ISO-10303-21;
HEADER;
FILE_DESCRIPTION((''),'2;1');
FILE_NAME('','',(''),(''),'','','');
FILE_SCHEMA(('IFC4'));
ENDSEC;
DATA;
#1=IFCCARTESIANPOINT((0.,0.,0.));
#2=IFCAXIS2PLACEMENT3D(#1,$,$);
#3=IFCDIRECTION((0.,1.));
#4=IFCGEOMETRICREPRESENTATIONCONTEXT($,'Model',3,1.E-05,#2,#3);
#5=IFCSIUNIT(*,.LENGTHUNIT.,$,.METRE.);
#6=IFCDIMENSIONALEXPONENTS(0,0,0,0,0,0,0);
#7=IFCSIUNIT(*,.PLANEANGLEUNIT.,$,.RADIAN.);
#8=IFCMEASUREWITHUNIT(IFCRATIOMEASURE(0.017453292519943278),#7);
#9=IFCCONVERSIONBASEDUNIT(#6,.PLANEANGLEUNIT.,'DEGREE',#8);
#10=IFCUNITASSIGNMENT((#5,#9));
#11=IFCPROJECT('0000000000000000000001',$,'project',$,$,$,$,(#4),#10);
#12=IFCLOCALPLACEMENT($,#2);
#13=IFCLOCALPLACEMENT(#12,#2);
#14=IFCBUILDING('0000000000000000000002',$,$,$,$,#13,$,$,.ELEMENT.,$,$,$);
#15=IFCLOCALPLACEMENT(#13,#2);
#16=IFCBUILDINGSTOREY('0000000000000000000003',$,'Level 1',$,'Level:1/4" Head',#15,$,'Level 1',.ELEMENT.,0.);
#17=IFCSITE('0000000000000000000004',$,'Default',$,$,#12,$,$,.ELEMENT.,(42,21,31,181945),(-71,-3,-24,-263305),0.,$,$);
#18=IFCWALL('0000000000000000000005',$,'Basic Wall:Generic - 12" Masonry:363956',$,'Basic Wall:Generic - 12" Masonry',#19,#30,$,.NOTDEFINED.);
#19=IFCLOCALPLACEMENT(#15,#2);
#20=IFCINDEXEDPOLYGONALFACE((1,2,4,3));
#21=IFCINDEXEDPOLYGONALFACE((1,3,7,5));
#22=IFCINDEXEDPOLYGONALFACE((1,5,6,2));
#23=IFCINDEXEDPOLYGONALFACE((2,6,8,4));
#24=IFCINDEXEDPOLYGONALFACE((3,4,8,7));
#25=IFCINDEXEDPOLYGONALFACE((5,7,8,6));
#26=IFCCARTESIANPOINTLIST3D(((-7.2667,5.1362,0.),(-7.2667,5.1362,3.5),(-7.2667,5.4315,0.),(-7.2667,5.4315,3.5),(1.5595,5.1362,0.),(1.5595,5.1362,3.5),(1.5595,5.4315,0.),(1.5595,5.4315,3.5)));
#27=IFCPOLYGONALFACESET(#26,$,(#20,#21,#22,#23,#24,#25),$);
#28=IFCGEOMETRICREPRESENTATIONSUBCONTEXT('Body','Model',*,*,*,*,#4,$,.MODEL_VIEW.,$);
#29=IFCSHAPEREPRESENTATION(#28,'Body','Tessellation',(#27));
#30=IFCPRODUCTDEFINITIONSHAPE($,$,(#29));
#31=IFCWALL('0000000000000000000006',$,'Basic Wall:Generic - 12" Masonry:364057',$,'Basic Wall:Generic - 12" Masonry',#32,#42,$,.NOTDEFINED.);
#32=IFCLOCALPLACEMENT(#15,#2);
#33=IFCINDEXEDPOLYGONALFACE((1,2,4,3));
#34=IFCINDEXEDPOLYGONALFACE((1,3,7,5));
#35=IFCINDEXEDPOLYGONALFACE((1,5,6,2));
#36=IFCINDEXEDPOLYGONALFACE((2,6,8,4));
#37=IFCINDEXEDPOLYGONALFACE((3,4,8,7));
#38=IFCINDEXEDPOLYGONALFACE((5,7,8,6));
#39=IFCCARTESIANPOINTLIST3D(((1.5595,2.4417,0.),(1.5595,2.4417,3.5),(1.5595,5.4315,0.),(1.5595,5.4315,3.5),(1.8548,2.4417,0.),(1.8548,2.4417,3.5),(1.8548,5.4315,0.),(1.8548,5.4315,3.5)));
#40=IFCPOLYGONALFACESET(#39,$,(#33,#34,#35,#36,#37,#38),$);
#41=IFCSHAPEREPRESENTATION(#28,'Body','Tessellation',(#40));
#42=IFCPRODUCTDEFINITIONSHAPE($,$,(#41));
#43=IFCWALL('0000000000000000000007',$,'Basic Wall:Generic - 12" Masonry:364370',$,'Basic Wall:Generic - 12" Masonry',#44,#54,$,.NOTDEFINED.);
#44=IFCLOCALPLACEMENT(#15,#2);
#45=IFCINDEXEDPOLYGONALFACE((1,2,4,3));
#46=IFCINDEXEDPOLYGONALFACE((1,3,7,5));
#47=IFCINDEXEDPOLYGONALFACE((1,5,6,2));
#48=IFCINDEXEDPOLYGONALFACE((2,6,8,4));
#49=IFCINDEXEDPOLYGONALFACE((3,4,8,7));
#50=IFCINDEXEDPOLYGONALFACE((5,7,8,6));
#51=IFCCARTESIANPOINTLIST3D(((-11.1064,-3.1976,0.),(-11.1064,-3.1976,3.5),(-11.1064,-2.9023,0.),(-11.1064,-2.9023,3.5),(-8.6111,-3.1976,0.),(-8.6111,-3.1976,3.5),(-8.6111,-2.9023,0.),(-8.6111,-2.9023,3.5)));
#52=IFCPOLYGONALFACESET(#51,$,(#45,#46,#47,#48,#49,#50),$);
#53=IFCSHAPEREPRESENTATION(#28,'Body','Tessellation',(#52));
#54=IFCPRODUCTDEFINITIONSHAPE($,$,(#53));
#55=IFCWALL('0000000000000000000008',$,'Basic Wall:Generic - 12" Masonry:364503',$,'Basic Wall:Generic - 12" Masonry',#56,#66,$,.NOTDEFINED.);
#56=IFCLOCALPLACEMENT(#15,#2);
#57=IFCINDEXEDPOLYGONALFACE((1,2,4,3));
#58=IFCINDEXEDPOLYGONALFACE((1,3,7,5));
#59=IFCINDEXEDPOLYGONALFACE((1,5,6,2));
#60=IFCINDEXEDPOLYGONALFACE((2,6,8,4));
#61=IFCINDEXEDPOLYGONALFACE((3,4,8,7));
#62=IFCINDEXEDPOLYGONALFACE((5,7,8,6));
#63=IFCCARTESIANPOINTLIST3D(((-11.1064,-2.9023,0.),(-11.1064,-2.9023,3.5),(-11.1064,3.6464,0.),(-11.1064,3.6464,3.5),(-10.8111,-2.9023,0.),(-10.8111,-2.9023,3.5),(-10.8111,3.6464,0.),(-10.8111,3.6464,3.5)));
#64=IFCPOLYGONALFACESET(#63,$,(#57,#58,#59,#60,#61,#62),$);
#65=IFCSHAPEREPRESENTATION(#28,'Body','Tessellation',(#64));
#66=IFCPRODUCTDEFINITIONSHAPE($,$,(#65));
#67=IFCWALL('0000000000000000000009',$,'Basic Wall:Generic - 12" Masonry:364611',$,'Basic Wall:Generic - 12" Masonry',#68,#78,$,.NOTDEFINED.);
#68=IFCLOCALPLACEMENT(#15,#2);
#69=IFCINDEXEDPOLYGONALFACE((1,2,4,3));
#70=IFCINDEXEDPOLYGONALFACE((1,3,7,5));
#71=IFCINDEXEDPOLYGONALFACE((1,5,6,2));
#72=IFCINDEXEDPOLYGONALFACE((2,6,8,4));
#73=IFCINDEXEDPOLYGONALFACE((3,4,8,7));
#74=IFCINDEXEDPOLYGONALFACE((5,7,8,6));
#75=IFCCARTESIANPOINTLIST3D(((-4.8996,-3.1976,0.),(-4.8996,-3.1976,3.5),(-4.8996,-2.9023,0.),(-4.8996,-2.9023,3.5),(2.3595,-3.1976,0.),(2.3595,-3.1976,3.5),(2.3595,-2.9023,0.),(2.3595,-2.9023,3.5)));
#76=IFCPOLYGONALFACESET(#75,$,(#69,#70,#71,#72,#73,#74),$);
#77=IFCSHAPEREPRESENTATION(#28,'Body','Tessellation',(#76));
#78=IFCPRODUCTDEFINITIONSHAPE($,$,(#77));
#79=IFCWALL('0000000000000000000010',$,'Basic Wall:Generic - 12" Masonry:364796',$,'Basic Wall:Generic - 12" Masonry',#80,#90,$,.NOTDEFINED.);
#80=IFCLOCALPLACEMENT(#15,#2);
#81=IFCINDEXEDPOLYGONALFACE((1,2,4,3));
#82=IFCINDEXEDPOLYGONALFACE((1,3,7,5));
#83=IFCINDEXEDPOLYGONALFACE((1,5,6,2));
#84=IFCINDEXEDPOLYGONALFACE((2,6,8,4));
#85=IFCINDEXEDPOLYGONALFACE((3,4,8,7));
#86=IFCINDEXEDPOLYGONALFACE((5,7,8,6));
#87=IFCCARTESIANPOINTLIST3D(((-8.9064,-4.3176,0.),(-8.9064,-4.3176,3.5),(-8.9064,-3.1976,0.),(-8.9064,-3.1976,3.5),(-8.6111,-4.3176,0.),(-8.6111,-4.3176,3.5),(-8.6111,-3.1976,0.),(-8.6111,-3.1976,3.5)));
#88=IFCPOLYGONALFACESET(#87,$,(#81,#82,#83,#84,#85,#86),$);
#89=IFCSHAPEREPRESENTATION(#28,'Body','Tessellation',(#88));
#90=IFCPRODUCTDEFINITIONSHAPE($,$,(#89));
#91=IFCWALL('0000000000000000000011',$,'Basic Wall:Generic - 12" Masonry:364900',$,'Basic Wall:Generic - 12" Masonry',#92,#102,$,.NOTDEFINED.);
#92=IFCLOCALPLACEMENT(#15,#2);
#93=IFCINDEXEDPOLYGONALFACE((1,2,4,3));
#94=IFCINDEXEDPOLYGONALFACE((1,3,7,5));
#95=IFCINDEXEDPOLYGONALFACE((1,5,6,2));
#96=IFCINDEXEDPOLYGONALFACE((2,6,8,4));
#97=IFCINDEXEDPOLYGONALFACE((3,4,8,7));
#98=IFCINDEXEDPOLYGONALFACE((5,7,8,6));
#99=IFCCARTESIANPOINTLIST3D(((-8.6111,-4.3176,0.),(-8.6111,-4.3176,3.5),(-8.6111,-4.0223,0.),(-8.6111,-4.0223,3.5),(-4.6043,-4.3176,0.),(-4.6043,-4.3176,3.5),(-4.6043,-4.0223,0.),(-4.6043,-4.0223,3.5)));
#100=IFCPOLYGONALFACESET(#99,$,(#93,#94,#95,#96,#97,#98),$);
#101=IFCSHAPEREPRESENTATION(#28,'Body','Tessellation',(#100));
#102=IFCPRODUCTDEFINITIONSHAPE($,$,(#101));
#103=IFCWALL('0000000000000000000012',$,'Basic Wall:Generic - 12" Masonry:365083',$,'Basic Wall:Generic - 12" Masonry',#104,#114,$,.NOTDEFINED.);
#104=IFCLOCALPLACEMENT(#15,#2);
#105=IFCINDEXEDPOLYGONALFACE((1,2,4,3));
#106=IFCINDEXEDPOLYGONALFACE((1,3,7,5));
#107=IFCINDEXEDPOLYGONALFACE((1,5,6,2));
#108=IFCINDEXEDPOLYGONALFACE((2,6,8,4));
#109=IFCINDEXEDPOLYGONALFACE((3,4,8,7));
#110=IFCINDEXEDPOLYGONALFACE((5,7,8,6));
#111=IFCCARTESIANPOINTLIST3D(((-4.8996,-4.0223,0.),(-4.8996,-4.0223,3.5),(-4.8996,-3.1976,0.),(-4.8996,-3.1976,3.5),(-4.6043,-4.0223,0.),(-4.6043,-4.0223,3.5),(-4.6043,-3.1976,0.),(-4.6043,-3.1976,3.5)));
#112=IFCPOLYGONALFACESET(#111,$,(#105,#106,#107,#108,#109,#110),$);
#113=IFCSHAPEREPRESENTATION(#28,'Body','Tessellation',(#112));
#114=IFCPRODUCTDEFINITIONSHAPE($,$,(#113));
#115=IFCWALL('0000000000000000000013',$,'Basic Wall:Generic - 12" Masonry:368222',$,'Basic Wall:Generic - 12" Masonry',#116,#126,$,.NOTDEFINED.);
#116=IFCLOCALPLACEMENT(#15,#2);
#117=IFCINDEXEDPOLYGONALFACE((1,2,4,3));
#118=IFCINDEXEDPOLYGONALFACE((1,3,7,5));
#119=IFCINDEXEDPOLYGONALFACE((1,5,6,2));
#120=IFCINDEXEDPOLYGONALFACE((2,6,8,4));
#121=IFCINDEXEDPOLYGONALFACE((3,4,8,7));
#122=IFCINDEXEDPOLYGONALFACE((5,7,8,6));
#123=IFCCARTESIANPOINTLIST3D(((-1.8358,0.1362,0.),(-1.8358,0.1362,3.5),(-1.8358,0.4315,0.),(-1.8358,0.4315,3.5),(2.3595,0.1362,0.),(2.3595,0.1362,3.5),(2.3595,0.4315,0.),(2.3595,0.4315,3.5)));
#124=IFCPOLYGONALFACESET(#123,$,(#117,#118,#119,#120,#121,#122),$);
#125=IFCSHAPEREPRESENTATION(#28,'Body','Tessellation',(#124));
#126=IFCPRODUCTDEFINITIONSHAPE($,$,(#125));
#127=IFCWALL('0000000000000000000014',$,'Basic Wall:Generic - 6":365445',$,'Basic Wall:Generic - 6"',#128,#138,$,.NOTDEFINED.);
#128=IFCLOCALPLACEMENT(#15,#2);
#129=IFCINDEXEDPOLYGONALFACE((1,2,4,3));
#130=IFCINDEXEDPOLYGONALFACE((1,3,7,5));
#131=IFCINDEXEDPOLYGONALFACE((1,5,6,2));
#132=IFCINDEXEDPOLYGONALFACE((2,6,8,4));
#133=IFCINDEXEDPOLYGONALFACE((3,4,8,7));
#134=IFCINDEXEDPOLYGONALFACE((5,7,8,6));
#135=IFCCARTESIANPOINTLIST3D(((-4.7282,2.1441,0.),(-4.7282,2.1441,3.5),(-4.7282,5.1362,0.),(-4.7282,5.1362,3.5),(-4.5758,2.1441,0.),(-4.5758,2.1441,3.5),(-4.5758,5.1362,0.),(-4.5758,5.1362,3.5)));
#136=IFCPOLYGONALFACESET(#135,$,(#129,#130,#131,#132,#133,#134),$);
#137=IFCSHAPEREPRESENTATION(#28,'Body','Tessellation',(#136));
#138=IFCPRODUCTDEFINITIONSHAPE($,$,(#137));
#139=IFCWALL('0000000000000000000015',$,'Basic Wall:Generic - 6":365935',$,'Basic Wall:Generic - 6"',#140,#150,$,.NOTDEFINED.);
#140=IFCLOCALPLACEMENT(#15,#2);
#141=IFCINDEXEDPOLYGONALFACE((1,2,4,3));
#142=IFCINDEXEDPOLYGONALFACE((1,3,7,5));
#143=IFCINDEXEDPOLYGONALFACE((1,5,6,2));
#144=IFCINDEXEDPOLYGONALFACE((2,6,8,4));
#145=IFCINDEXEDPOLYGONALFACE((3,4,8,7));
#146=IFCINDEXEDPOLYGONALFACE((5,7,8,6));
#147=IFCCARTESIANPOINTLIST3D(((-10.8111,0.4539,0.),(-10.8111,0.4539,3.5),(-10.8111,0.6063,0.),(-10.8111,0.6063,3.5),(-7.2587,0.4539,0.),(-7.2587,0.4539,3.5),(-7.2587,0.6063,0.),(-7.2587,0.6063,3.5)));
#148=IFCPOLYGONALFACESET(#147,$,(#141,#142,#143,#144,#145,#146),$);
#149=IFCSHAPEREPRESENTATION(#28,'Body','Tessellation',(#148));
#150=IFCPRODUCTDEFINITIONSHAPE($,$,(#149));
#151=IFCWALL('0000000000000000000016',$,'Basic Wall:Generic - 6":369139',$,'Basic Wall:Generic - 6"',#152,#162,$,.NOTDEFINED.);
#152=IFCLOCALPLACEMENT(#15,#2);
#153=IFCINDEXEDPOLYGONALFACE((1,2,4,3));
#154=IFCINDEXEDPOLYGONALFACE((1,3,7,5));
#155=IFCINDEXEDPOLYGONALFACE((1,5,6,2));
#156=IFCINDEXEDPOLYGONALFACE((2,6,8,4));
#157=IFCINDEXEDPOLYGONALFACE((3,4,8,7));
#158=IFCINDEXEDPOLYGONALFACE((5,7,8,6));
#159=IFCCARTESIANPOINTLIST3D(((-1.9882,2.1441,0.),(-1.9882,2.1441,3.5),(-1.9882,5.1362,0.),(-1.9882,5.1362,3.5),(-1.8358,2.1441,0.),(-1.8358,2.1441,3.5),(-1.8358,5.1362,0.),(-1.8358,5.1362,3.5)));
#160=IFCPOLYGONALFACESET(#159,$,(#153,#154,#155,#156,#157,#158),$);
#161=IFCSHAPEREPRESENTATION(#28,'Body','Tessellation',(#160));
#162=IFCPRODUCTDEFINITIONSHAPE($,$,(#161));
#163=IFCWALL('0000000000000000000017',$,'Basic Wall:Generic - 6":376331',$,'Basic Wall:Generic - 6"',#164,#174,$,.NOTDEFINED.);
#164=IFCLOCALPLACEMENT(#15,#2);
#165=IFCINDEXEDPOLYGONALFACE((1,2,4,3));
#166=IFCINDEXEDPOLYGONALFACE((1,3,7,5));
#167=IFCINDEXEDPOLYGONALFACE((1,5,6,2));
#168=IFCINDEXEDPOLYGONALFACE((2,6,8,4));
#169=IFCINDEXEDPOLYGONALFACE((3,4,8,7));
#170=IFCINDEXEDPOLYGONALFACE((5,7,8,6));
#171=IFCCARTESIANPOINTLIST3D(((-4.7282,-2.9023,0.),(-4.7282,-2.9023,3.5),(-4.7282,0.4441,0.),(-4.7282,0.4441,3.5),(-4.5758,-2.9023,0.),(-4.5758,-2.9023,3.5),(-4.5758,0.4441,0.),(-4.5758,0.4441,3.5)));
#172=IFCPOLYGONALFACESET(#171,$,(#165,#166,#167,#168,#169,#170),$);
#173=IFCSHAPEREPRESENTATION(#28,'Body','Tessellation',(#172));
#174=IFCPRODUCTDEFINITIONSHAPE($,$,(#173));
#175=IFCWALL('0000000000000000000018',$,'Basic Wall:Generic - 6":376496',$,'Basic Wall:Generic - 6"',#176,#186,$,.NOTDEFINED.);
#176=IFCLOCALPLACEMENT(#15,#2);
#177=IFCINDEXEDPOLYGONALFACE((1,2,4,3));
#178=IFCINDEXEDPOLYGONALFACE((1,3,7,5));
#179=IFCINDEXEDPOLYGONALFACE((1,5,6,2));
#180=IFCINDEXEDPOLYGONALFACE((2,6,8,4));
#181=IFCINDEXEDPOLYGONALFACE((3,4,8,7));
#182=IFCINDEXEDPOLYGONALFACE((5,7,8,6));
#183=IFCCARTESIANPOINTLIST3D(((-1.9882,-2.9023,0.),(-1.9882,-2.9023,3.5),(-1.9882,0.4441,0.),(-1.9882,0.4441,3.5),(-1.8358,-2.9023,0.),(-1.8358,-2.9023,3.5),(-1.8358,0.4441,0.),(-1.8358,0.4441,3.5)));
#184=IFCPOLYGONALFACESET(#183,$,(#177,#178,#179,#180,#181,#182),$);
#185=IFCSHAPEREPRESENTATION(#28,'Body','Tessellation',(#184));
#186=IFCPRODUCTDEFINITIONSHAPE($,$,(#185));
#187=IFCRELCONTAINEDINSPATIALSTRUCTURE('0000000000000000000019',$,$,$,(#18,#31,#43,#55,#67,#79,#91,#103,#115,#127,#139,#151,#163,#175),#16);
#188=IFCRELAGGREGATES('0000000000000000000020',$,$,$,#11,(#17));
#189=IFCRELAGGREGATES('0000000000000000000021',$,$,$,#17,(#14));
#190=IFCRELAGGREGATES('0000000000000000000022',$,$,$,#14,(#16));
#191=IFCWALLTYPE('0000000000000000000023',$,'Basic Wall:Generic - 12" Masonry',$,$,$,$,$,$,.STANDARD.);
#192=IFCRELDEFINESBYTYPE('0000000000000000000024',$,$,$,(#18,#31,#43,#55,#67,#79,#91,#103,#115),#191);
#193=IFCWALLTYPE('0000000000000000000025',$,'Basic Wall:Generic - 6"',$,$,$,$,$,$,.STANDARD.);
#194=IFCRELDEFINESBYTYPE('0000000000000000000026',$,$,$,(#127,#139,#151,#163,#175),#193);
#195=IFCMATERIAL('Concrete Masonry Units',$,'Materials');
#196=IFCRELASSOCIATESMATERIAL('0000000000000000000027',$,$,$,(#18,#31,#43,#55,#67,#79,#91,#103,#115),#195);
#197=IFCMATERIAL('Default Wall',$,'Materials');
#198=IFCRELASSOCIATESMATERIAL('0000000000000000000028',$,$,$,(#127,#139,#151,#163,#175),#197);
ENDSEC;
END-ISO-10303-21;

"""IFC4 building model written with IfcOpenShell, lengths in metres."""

from ifc_helpers import new_model, entity, si_unit, converted_unit, direction, frame, origin, place, context, subcontext, project, spatial, indexed_curve, outline, extrude, material, type_object, element, save


model = new_model("IFC4")

# Units and contexts
model_context = context("Model", 3, precision=1e-05, world=origin(), true_north=direction((0.0, 1.0)))
body_context = subcontext(model_context, "Body", "Model", "MODEL_VIEW")
ifc_project = project(units=[si_unit("LENGTHUNIT", "METRE"), converted_unit("PLANEANGLEUNIT", "DEGREE", entity("IfcRatioMeasure", 0.017453292519943278), si_unit("PLANEANGLEUNIT", "RADIAN"), dimensions=[0, 0, 0, 0, 0, 0, 0])], contexts=[model_context])

# Site, building, storey
site_placement = place(None, origin())
site = spatial("IfcSite", under=ifc_project, at=site_placement, Name="Default", CompositionType="ELEMENT", RefLatitude=(42, 21, 31, 181945), RefLongitude=(-71, -3, -24, -263305), RefElevation=0.0)
building_placement = place(site_placement, origin())
building = spatial("IfcBuilding", under=site, at=building_placement, CompositionType="ELEMENT")
storey_placement = place(building_placement, origin())
storey = spatial("IfcBuildingStorey", under=building, at=storey_placement, Name="Level 1", ObjectType="Level:1/4\" Head", LongName="Level 1", CompositionType="ELEMENT", Elevation=0.0)

# Walls
ifc_material_1 = material(Name="Concrete Masonry Units", Category="Materials")
wall_type_1 = type_object("IfcWallType", Name="Basic Wall:Generic - 12\" Masonry", PredefinedType="STANDARD")
wall_1_placement = place(storey_placement, frame((1.5595, 5.2838, 0.0), z_axis=(0.0, 0.0, 1.0), x_axis=(-1.0, 0.0, 0.0)))
element("IfcWall", 1, at=wall_1_placement, inside=storey, type_object=wall_type_1, material=ifc_material_1, Name="Basic Wall:Generic - 12\" Masonry:363956", ObjectType="Basic Wall:Generic - 12\" Masonry", PredefinedType="NOTDEFINED", context=body_context, shape_type="SweptSolid", body=[
    extrude(outline(indexed_curve([(8.8262, 0.1476), (0.0, 0.1476), (0.0, -0.1476), (8.8262, -0.1476), (8.8262, 0.1476)], self_intersect=False)), origin(), (0.0, 0.0, 1.0), 3.5),
])
wall_2_placement = place(storey_placement, frame((1.7071, 5.4315, 0.0), z_axis=(0.0, 0.0, 1.0), x_axis=(0.0, -1.0, 0.0)))
element("IfcWall", 2, at=wall_2_placement, inside=storey, type_object=wall_type_1, material=ifc_material_1, Name="Basic Wall:Generic - 12\" Masonry:364057", ObjectType="Basic Wall:Generic - 12\" Masonry", PredefinedType="NOTDEFINED", context=body_context, shape_type="SweptSolid", body=[
    extrude(outline(indexed_curve([(2.9897, 0.1476), (0.0, 0.1476), (0.0, -0.1476), (2.9897, -0.1476), (2.9897, 0.1476)], self_intersect=False)), origin(), (0.0, 0.0, 1.0), 3.5),
])
wall_3_placement = place(storey_placement, frame((-8.6111, -3.0499, 0.0), z_axis=(0.0, 0.0, 1.0), x_axis=(-1.0, 0.0, 0.0)))
element("IfcWall", 3, at=wall_3_placement, inside=storey, type_object=wall_type_1, material=ifc_material_1, Name="Basic Wall:Generic - 12\" Masonry:364370", ObjectType="Basic Wall:Generic - 12\" Masonry", PredefinedType="NOTDEFINED", context=body_context, shape_type="SweptSolid", body=[
    extrude(outline(indexed_curve([(2.4953, 0.1476), (0.0, 0.1476), (0.0, -0.1476), (2.4953, -0.1476), (2.4953, 0.1476)], self_intersect=False)), origin(), (0.0, 0.0, 1.0), 3.5),
])
wall_4_placement = place(storey_placement, frame((-10.9587, 3.6464, 0.0), z_axis=(0.0, 0.0, 1.0), x_axis=(0.0, -1.0, 0.0)))
element("IfcWall", 4, at=wall_4_placement, inside=storey, type_object=wall_type_1, material=ifc_material_1, Name="Basic Wall:Generic - 12\" Masonry:364503", ObjectType="Basic Wall:Generic - 12\" Masonry", PredefinedType="NOTDEFINED", context=body_context, shape_type="SweptSolid", body=[
    extrude(outline(indexed_curve([(6.5487, 0.1476), (0.0, 0.1476), (0.0, -0.1476), (6.5487, -0.1476), (6.5487, 0.1476)], self_intersect=False)), origin(), (0.0, 0.0, 1.0), 3.5),
])
wall_5_placement = place(storey_placement, frame((2.3595, -3.0499, 0.0), z_axis=(0.0, 0.0, 1.0), x_axis=(-1.0, 0.0, 0.0)))
element("IfcWall", 5, at=wall_5_placement, inside=storey, type_object=wall_type_1, material=ifc_material_1, Name="Basic Wall:Generic - 12\" Masonry:364611", ObjectType="Basic Wall:Generic - 12\" Masonry", PredefinedType="NOTDEFINED", context=body_context, shape_type="SweptSolid", body=[
    extrude(outline(indexed_curve([(7.2591, 0.1476), (0.0, 0.1476), (0.0, -0.1476), (7.2591, -0.1476), (7.2591, 0.1476)], self_intersect=False)), origin(), (0.0, 0.0, 1.0), 3.5),
])
wall_6_placement = place(storey_placement, frame((-8.7587, -3.1976, 0.0), z_axis=(0.0, 0.0, 1.0), x_axis=(0.0, -1.0, 0.0)))
element("IfcWall", 6, at=wall_6_placement, inside=storey, type_object=wall_type_1, material=ifc_material_1, Name="Basic Wall:Generic - 12\" Masonry:364796", ObjectType="Basic Wall:Generic - 12\" Masonry", PredefinedType="NOTDEFINED", context=body_context, shape_type="SweptSolid", body=[
    extrude(outline(indexed_curve([(1.12, 0.1476), (0.0, 0.1476), (0.0, -0.1476), (1.12, -0.1476), (1.12, 0.1476)], self_intersect=False)), origin(), (0.0, 0.0, 1.0), 3.5),
])
wall_7_placement = place(storey_placement, frame((-4.6043, -4.1699, 0.0), z_axis=(0.0, 0.0, 1.0), x_axis=(-1.0, 0.0, 0.0)))
element("IfcWall", 7, at=wall_7_placement, inside=storey, type_object=wall_type_1, material=ifc_material_1, Name="Basic Wall:Generic - 12\" Masonry:364900", ObjectType="Basic Wall:Generic - 12\" Masonry", PredefinedType="NOTDEFINED", context=body_context, shape_type="SweptSolid", body=[
    extrude(outline(indexed_curve([(4.0068, 0.1476), (0.0, 0.1476), (0.0, -0.1476), (4.0068, -0.1476), (4.0068, 0.1476)], self_intersect=False)), origin(), (0.0, 0.0, 1.0), 3.5),
])
wall_8_placement = place(storey_placement, frame((-4.752, -4.0223, 0.0), z_axis=(0.0, 0.0, 1.0), x_axis=(0.0, 1.0, 0.0)))
element("IfcWall", 8, at=wall_8_placement, inside=storey, type_object=wall_type_1, material=ifc_material_1, Name="Basic Wall:Generic - 12\" Masonry:365083", ObjectType="Basic Wall:Generic - 12\" Masonry", PredefinedType="NOTDEFINED", context=body_context, shape_type="SweptSolid", body=[
    extrude(outline(indexed_curve([(0.8247, 0.1476), (0.0, 0.1476), (0.0, -0.1476), (0.8247, -0.1476), (0.8247, 0.1476)], self_intersect=False)), origin(), (0.0, 0.0, 1.0), 3.5),
])
wall_9_placement = place(storey_placement, frame((-1.8358, 0.2838, 0.0)))
element("IfcWall", 9, at=wall_9_placement, inside=storey, type_object=wall_type_1, material=ifc_material_1, Name="Basic Wall:Generic - 12\" Masonry:368222", ObjectType="Basic Wall:Generic - 12\" Masonry", PredefinedType="NOTDEFINED", context=body_context, shape_type="SweptSolid", body=[
    extrude(outline(indexed_curve([(4.1953, 0.1476), (0.0, 0.1476), (0.0, -0.1476), (4.1953, -0.1476), (4.1953, 0.1476)], self_intersect=False)), origin(), (0.0, 0.0, 1.0), 3.5),
])
ifc_material_2 = material(Name="Default Wall", Category="Materials")
wall_type_2 = type_object("IfcWallType", Name="Basic Wall:Generic - 6\"", PredefinedType="STANDARD")
wall_10_placement = place(storey_placement, frame((-4.652, 5.1362, 0.0), z_axis=(0.0, 0.0, 1.0), x_axis=(0.0, -1.0, 0.0)))
element("IfcWall", 10, at=wall_10_placement, inside=storey, type_object=wall_type_2, material=ifc_material_2, Name="Basic Wall:Generic - 6\":365445", ObjectType="Basic Wall:Generic - 6\"", PredefinedType="NOTDEFINED", context=body_context, shape_type="SweptSolid", body=[
    extrude(outline(indexed_curve([(2.9921, 0.0762), (0.0, 0.0762), (0.0, -0.0762), (2.9921, -0.0762), (2.9921, 0.0762)], self_intersect=False)), origin(), (0.0, 0.0, 1.0), 3.5),
])
wall_11_placement = place(storey_placement, frame((-10.8111, 0.5301, 0.0)))
element("IfcWall", 11, at=wall_11_placement, inside=storey, type_object=wall_type_2, material=ifc_material_2, Name="Basic Wall:Generic - 6\":365935", ObjectType="Basic Wall:Generic - 6\"", PredefinedType="NOTDEFINED", context=body_context, shape_type="SweptSolid", body=[
    extrude(outline(indexed_curve([(3.5524, 0.0762), (0.0, 0.0762), (0.0, -0.0762), (3.5524, -0.0762), (3.5524, 0.0762)], self_intersect=False)), origin(), (0.0, 0.0, 1.0), 3.5),
])
wall_12_placement = place(storey_placement, frame((-1.912, 5.1362, 0.0), z_axis=(0.0, 0.0, 1.0), x_axis=(0.0, -1.0, 0.0)))
element("IfcWall", 12, at=wall_12_placement, inside=storey, type_object=wall_type_2, material=ifc_material_2, Name="Basic Wall:Generic - 6\":369139", ObjectType="Basic Wall:Generic - 6\"", PredefinedType="NOTDEFINED", context=body_context, shape_type="SweptSolid", body=[
    extrude(outline(indexed_curve([(2.9921, 0.0762), (0.0, 0.0762), (0.0, -0.0762), (2.9921, -0.0762), (2.9921, 0.0762)], self_intersect=False)), origin(), (0.0, 0.0, 1.0), 3.5),
])
wall_13_placement = place(storey_placement, frame((-4.652, 0.4441, 0.0), z_axis=(0.0, 0.0, 1.0), x_axis=(0.0, -1.0, 0.0)))
element("IfcWall", 13, at=wall_13_placement, inside=storey, type_object=wall_type_2, material=ifc_material_2, Name="Basic Wall:Generic - 6\":376331", ObjectType="Basic Wall:Generic - 6\"", PredefinedType="NOTDEFINED", context=body_context, shape_type="SweptSolid", body=[
    extrude(outline(indexed_curve([(3.3464, 0.0762), (0.0, 0.0762), (0.0, -0.0762), (3.3464, -0.0762), (3.3464, 0.0762)], self_intersect=False)), origin(), (0.0, 0.0, 1.0), 3.5),
])
wall_14_placement = place(storey_placement, frame((-1.912, 0.4441, 0.0), z_axis=(0.0, 0.0, 1.0), x_axis=(0.0, -1.0, 0.0)))
element("IfcWall", 14, at=wall_14_placement, inside=storey, type_object=wall_type_2, material=ifc_material_2, Name="Basic Wall:Generic - 6\":376496", ObjectType="Basic Wall:Generic - 6\"", PredefinedType="NOTDEFINED", context=body_context, shape_type="SweptSolid", body=[
    extrude(outline(indexed_curve([(3.3464, 0.0762), (0.0, 0.0762), (0.0, -0.0762), (3.3464, -0.0762), (3.3464, 0.0762)], self_intersect=False)), origin(), (0.0, 0.0, 1.0), 3.5),
])

save(model, "model.ifc")
